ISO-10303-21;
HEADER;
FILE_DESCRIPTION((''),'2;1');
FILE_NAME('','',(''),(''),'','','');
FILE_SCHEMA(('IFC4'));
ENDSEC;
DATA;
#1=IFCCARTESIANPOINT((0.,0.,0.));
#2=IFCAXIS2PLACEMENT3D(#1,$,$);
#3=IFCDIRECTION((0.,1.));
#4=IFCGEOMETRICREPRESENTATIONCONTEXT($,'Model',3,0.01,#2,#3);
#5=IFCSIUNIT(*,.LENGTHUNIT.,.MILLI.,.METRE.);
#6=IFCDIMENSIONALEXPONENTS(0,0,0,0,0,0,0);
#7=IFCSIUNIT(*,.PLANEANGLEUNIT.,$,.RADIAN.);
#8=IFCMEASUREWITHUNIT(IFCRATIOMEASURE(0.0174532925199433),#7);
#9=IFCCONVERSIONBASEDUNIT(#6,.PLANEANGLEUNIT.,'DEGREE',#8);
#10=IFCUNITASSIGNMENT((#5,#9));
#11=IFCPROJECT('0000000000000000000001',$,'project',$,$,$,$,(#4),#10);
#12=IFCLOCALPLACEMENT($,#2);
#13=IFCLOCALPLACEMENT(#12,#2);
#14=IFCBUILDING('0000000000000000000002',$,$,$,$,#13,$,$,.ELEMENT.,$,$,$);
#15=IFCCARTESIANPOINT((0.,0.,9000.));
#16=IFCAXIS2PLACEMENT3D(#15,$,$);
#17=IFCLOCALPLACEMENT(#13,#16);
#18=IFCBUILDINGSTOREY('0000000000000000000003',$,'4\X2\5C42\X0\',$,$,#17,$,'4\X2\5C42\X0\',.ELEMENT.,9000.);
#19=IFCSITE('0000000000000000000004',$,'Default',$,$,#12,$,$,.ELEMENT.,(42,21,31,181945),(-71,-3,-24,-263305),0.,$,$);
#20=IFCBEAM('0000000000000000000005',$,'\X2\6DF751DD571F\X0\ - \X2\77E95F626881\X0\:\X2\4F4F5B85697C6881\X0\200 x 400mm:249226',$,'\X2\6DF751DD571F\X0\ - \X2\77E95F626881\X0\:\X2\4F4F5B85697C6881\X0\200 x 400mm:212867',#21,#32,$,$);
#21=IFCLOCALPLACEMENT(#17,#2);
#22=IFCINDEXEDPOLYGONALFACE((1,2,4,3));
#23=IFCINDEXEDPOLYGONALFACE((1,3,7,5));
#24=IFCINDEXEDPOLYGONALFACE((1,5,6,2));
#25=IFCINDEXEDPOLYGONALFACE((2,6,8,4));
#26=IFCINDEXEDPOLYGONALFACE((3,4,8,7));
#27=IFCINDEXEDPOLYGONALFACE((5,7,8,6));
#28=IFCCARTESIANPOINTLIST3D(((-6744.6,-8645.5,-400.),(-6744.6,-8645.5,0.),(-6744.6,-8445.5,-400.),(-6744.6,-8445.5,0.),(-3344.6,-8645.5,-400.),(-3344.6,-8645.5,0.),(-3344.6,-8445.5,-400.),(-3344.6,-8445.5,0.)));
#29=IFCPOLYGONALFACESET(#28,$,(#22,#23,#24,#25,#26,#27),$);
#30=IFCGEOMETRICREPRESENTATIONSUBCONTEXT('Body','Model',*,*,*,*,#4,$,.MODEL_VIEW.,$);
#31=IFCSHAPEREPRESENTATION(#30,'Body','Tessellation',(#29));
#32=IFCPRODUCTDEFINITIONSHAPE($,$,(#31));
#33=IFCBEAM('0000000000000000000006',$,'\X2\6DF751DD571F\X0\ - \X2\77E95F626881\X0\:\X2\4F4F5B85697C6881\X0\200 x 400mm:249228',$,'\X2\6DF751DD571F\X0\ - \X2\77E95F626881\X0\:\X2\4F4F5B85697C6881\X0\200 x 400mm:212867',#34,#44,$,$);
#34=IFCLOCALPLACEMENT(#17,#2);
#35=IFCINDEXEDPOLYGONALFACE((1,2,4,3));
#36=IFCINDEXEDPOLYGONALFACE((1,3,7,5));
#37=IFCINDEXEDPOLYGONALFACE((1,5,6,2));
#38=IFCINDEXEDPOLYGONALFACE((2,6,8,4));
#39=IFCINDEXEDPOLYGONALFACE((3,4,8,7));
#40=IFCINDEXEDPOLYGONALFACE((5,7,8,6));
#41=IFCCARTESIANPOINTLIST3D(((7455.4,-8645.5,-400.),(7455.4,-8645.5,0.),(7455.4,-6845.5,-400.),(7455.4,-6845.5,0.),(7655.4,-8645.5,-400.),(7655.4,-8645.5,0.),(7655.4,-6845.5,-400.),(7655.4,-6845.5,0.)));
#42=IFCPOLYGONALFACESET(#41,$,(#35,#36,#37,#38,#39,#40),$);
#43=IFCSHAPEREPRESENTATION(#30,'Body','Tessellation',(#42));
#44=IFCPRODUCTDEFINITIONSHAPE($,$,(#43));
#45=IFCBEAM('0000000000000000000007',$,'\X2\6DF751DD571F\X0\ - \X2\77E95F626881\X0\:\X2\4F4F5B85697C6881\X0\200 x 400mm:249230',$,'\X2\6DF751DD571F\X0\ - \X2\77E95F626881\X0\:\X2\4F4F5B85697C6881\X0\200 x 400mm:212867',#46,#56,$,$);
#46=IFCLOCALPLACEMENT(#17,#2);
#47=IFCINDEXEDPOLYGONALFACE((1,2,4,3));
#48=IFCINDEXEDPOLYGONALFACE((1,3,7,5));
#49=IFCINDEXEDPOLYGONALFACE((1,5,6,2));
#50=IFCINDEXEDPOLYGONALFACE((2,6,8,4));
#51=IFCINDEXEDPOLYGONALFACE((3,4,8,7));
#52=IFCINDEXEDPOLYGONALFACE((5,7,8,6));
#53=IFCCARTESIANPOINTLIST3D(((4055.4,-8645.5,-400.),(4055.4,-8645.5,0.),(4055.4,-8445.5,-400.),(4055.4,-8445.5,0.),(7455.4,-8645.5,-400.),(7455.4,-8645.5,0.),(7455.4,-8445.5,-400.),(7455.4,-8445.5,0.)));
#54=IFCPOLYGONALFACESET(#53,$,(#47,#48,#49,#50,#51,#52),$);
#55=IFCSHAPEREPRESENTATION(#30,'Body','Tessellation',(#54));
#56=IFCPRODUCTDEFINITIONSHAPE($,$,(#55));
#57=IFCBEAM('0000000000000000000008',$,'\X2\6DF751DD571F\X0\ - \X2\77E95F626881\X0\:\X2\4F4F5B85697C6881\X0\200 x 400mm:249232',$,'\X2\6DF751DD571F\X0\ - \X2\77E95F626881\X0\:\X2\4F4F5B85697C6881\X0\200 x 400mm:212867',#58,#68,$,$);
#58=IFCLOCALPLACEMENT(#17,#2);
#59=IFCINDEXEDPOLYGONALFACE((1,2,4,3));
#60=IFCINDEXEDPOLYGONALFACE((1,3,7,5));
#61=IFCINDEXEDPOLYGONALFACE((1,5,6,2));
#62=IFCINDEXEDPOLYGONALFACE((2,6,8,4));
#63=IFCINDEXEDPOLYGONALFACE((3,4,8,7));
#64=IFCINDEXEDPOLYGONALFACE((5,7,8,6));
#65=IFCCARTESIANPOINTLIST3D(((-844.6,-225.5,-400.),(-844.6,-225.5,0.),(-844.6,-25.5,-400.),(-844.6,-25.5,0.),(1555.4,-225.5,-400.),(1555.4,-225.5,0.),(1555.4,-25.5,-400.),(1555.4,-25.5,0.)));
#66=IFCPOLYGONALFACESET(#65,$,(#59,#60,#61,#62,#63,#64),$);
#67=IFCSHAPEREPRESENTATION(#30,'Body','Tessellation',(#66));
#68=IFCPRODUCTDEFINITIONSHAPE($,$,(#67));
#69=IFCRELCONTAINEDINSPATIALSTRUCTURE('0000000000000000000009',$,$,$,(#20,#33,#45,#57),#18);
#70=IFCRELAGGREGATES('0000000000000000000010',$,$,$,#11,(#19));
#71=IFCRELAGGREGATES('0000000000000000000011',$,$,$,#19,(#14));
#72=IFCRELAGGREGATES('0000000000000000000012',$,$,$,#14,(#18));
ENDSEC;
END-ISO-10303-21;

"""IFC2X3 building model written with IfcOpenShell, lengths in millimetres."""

from ifc_helpers import new_model, entity, si_unit, converted_unit, direction, frame, frame_2d, origin, place, context, subcontext, project, spatial, rectangle, extrude, element, save


model = new_model("IFC2X3")

# Units and contexts
model_context = context("Model", 3, precision=0.01, world=origin(), true_north=direction((0.0, 1.0)))
body_context = subcontext(model_context, "Body", "Model", "MODEL_VIEW")
ifc_project = project(units=[si_unit("LENGTHUNIT", "METRE", prefix="MILLI"), converted_unit("PLANEANGLEUNIT", "DEGREE", entity("IfcRatioMeasure", 0.0174532925199433), si_unit("PLANEANGLEUNIT", "RADIAN"), dimensions=[0, 0, 0, 0, 0, 0, 0])], contexts=[model_context])

# Site, building, storey
site_placement = place(None, origin())
site = spatial("IfcSite", under=ifc_project, at=site_placement, Name="Default", CompositionType="ELEMENT", RefLatitude=(42, 21, 31, 181945), RefLongitude=(-71, -3, -24, -263305), RefElevation=0.0)
building_placement = place(site_placement, origin())
building = spatial("IfcBuilding", under=site, at=building_placement, CompositionType="ELEMENT")
storey_placement = place(building_placement, frame((0.0, 0.0, 9000.0)))
storey = spatial("IfcBuildingStorey", under=building, at=storey_placement, Name="4层", LongName="4层", CompositionType="ELEMENT", Elevation=9000.0)

# Beams
beam_1_placement = place(storey_placement, frame((-6844.6, -8545.5, 0.0)))
element("IfcBeam", 1, at=beam_1_placement, inside=storey, Name="混凝土 - 矩形梁:住宅楼梁200 x 400mm:249226", ObjectType="混凝土 - 矩形梁:住宅楼梁200 x 400mm:212867", context=body_context, shape_type="SweptSolid", body=[
    extrude(rectangle(XDim=400.0, YDim=200.0, at=frame_2d((0.0, 0.0), x_axis=(1.0, 0.0))), frame((100.0, 0.0, -200.0), z_axis=(1.0, 0.0, 0.0), x_axis=(0.0, 0.0, -1.0)), (0.0, 0.0, 1.0), 3400.0),
])
beam_2_placement = place(storey_placement, frame((7555.4, -6745.5, 0.0), z_axis=(0.0, 0.0, 1.0), x_axis=(0.0, -1.0, 0.0)))
element("IfcBeam", 2, at=beam_2_placement, inside=storey, Name="混凝土 - 矩形梁:住宅楼梁200 x 400mm:249228", ObjectType="混凝土 - 矩形梁:住宅楼梁200 x 400mm:212867", context=body_context, shape_type="SweptSolid", body=[
    extrude(rectangle(XDim=400.0, YDim=200.0, at=frame_2d((0.0, 0.0), x_axis=(1.0, 0.0))), frame((100.0, 0.0, -200.0), z_axis=(1.0, 0.0, 0.0), x_axis=(0.0, 0.0, -1.0)), (0.0, 0.0, 1.0), 1800.0),
])
beam_3_placement = place(storey_placement, frame((7555.4, -8545.5, 0.0), z_axis=(0.0, 0.0, 1.0), x_axis=(-1.0, 0.0, 0.0)))
element("IfcBeam", 3, at=beam_3_placement, inside=storey, Name="混凝土 - 矩形梁:住宅楼梁200 x 400mm:249230", ObjectType="混凝土 - 矩形梁:住宅楼梁200 x 400mm:212867", context=body_context, shape_type="SweptSolid", body=[
    extrude(rectangle(XDim=400.0, YDim=200.0, at=frame_2d((0.0, 0.0), x_axis=(1.0, 0.0))), frame((100.0, 0.0, -200.0), z_axis=(1.0, 0.0, 0.0), x_axis=(0.0, 0.0, -1.0)), (0.0, 0.0, 1.0), 3400.0),
])
beam_4_placement = place(storey_placement, frame((-944.6, -125.5, 0.0)))
element("IfcBeam", 4, at=beam_4_placement, inside=storey, Name="混凝土 - 矩形梁:住宅楼梁200 x 400mm:249232", ObjectType="混凝土 - 矩形梁:住宅楼梁200 x 400mm:212867", context=body_context, shape_type="SweptSolid", body=[
    extrude(rectangle(XDim=400.0, YDim=200.0, at=frame_2d((0.0, 0.0), x_axis=(1.0, 0.0))), frame((100.0, 0.0, -200.0), z_axis=(1.0, 0.0, 0.0), x_axis=(0.0, 0.0, -1.0)), (0.0, 0.0, 1.0), 2400.0),
])

save(model, "model.ifc")
